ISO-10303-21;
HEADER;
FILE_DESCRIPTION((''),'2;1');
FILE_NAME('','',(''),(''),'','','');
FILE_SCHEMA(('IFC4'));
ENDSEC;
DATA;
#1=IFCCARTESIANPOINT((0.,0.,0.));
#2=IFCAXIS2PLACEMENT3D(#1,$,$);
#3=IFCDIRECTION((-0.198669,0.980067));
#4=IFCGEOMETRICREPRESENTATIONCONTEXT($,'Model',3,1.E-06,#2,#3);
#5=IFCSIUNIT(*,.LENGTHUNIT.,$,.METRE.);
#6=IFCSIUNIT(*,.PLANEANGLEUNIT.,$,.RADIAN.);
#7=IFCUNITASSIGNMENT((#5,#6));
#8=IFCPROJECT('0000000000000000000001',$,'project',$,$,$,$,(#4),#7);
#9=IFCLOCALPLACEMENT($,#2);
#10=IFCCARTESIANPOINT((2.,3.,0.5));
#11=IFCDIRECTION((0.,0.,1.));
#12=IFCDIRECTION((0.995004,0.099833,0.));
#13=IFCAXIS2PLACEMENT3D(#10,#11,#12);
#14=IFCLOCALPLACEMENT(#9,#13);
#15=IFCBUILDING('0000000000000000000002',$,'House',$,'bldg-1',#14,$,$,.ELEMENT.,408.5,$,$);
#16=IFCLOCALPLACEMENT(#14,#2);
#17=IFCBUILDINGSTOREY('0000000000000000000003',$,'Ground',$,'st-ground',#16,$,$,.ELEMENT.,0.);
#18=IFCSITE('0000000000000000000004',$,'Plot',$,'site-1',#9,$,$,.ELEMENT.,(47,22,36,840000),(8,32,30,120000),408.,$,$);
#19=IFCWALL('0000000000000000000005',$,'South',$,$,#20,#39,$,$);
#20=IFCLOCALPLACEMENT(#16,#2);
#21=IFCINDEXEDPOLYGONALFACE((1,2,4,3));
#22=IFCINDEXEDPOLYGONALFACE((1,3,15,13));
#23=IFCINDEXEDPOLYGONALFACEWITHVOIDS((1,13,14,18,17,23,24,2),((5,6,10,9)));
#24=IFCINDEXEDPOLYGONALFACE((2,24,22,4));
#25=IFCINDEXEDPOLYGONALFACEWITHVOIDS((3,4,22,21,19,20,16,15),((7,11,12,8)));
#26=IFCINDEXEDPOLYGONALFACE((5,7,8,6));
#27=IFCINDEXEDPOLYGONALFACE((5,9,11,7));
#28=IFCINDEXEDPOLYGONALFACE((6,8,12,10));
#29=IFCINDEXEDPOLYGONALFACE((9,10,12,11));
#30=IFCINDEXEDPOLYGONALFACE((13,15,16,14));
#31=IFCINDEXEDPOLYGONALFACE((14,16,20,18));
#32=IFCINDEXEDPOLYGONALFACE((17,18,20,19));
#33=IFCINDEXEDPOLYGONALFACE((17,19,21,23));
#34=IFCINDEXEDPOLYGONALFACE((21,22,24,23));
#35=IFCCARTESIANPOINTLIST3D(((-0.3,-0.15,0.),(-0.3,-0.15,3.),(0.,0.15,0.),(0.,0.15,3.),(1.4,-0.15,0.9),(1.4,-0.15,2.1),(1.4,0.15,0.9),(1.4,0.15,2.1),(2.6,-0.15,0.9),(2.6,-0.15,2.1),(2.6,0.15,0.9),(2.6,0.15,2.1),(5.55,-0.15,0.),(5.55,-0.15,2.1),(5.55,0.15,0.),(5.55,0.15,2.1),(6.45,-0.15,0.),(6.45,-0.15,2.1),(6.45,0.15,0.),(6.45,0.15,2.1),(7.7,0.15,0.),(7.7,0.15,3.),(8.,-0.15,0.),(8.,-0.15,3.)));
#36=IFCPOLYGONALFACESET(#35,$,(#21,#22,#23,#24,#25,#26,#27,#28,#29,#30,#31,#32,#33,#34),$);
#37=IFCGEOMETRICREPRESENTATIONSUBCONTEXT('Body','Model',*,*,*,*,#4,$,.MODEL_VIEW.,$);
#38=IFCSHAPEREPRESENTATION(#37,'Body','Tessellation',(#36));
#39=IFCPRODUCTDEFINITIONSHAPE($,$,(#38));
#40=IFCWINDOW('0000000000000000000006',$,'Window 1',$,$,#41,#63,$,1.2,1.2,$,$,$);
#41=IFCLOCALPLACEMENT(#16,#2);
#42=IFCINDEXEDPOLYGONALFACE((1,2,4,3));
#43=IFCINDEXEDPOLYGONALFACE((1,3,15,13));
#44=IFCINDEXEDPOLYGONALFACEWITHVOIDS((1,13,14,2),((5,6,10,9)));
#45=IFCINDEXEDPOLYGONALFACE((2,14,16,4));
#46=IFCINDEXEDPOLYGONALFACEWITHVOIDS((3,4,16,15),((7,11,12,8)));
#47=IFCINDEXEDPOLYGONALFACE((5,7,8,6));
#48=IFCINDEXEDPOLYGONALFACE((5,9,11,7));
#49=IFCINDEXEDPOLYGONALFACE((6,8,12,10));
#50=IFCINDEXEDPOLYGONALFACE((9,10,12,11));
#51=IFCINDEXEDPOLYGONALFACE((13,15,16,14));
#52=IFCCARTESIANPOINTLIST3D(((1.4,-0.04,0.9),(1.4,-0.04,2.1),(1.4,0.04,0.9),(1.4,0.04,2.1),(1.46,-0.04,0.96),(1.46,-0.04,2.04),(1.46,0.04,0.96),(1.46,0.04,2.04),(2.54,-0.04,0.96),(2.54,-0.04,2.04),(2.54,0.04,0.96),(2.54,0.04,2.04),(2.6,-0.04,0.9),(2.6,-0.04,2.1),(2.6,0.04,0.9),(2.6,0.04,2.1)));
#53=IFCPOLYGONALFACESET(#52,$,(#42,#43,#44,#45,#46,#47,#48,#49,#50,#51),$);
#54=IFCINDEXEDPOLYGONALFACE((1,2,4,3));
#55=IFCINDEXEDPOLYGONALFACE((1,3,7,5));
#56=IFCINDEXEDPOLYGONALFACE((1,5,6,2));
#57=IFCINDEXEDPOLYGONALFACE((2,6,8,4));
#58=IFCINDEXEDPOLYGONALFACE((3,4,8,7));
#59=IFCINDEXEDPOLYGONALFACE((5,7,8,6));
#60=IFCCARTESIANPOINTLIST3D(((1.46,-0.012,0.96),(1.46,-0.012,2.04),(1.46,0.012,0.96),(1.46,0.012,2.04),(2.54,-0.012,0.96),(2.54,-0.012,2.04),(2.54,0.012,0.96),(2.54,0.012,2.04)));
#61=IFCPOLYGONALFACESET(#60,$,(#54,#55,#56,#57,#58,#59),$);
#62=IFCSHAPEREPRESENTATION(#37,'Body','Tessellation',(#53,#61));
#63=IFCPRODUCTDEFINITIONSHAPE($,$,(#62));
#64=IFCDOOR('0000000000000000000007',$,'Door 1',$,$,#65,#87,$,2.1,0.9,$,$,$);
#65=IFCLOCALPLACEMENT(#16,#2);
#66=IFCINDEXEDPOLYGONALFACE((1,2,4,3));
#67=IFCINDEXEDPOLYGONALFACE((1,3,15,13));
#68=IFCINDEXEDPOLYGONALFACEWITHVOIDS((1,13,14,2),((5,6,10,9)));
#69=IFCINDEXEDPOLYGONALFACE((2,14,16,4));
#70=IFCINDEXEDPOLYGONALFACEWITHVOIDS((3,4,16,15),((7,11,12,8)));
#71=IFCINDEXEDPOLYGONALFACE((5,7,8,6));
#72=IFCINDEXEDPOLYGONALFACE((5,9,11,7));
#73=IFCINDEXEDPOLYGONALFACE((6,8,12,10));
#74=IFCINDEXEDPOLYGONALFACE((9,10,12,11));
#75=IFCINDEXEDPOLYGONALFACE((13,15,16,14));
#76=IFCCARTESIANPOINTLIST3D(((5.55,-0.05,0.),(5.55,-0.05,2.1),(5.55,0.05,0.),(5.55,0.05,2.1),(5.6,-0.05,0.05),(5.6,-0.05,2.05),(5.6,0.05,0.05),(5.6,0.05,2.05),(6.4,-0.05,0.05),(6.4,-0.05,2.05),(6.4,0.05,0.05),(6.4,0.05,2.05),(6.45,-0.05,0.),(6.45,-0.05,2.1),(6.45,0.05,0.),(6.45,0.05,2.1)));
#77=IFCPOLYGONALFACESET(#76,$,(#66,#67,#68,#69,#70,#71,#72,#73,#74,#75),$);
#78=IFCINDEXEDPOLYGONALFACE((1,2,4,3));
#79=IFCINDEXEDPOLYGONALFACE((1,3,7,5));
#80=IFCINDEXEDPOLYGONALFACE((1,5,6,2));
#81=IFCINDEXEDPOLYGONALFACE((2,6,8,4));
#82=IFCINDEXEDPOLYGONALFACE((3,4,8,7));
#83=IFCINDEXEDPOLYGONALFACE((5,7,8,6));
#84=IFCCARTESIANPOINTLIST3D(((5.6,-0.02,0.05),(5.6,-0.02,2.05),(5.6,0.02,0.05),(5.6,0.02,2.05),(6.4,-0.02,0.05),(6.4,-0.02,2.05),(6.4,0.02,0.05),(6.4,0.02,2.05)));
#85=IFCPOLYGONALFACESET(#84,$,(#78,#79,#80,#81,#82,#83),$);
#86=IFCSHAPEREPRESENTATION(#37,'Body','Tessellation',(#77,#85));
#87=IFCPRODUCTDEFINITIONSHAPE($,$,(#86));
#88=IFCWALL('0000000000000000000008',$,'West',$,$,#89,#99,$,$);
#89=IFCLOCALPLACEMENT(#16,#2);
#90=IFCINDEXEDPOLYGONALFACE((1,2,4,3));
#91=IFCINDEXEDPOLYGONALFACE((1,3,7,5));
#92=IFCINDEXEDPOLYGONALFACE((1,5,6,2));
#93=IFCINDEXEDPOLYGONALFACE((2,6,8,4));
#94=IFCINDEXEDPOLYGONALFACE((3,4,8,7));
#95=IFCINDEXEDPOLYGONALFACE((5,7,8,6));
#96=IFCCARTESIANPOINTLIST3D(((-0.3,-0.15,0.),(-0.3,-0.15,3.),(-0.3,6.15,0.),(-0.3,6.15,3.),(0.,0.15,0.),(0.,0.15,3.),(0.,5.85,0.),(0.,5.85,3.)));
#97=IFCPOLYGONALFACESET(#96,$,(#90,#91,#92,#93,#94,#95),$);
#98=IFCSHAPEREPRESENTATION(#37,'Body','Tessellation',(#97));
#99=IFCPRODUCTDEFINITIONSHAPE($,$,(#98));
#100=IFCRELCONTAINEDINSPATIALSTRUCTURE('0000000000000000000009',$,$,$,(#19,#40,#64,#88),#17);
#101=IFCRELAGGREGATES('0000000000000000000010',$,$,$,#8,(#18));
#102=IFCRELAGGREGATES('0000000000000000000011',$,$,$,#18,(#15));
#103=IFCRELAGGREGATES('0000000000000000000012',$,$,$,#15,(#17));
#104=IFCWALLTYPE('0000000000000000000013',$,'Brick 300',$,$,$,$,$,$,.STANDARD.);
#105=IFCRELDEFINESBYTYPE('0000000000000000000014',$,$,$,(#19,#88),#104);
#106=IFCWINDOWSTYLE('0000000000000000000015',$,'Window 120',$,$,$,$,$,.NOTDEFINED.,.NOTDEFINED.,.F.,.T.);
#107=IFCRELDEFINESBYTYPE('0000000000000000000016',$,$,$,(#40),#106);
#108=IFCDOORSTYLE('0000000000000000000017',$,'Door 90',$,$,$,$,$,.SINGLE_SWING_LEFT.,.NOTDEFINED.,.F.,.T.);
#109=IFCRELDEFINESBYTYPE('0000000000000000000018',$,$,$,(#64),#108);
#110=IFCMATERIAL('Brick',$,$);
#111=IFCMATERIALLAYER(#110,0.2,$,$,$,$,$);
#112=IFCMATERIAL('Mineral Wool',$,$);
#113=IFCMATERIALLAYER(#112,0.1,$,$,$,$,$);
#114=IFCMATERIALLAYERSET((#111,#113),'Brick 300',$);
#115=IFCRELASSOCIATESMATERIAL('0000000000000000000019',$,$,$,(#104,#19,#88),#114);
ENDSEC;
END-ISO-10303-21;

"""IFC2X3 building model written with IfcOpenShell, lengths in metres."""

from ifc_helpers import new_model, si_unit, direction, frame, frame_2d, origin, origin_2d, place, context, subcontext, project, spatial, polyline, rectangle, outline, extrude, material, layer, layer_set, layer_usage, type_object, element, fill, save


model = new_model("IFC2X3")

# Units and contexts
model_context = context("Model", 3, precision=1e-06, world=origin(), true_north=direction((-0.198669, 0.980067)))
body_context = subcontext(model_context, "Body", "Model", "MODEL_VIEW")
ifc_project = project(units=[si_unit("LENGTHUNIT", "METRE"), si_unit("PLANEANGLEUNIT", "RADIAN")], contexts=[model_context])

# Site, building, storey
site_placement = place(None, origin())
site = spatial("IfcSite", under=ifc_project, at=site_placement, Name="Plot", ObjectType="site-1", CompositionType="ELEMENT", RefLatitude=(47, 22, 36, 840000), RefLongitude=(8, 32, 30, 120000), RefElevation=408.0)
building_placement = place(site_placement, frame((2.0, 3.0, 0.5), z_axis=(0.0, 0.0, 1.0), x_axis=(0.995004, 0.099833, 0.0)))
building = spatial("IfcBuilding", under=site, at=building_placement, Name="House", ObjectType="bldg-1", CompositionType="ELEMENT", ElevationOfRefHeight=408.5)
storey_placement = place(building_placement, origin())
storey = spatial("IfcBuildingStorey", under=building, at=storey_placement, Name="Ground", ObjectType="st-ground", CompositionType="ELEMENT", Elevation=0.0)

# Shared definitions
window_style = type_object("IfcWindowStyle", Name="Window 120", ConstructionType="NOTDEFINED", OperationType="NOTDEFINED", ParameterTakesPrecedence=False, Sizeable=True)

# Shared definitions
ifc_material_1 = material(Name="Brick")
ifc_layer_1 = layer(ifc_material_1, 0.2)
ifc_material_2 = material(Name="Mineral Wool")
ifc_layer_2 = layer(ifc_material_2, 0.1)
ifc_layer_set_1 = layer_set([ifc_layer_1, ifc_layer_2], Name="Brick 300")
wall_type_1 = type_object("IfcWallType", Name="Brick 300", PredefinedType="STANDARD", material=ifc_layer_set_1)

# Wall, openings, window, door
ifc_layer_usage_1 = layer_usage(ifc_layer_set_1, "AXIS2", "NEGATIVE", 0.15)
wall_1_placement = place(storey_placement, origin())
wall_1 = element("IfcWall", 1, at=wall_1_placement, inside=storey, type_object=wall_type_1, material=ifc_layer_usage_1, Name="South", context=body_context, shape_type="SweptSolid", body=[
    extrude(outline(polyline([(-0.3, -0.15), (8.0, -0.15), (7.7, 0.15), (0.0, 0.15), (-0.3, -0.15)])), origin(), (0.0, 0.0, 1.0), 3.0),
])
opening_1_placement = place(wall_1_placement, frame((6.0, 0.0, 0.0), z_axis=(0.0, 0.0, 1.0), x_axis=(1.0, 0.0, 0.0)))
opening_1 = element("IfcOpeningElement", 2, at=opening_1_placement, cuts=wall_1, context=body_context, shape_type="SweptSolid", body=[
    extrude(rectangle(XDim=0.9, YDim=0.3, at=origin_2d()), origin(), (0.0, 0.0, 1.0), 2.1),
])
opening_2_placement = place(wall_1_placement, frame((2.0, 0.0, 0.9), z_axis=(0.0, 0.0, 1.0), x_axis=(1.0, 0.0, 0.0)))
opening_2 = element("IfcOpeningElement", 3, at=opening_2_placement, cuts=wall_1, context=body_context, shape_type="SweptSolid", body=[
    extrude(rectangle(XDim=1.2, YDim=0.3, at=origin_2d()), origin(), (0.0, 0.0, 1.0), 1.2),
])
window_1_placement = place(opening_2_placement, frame((0.0, 0.0, 0.0), z_axis=(0.0, -1.0, 0.0), x_axis=(1.0, 0.0, 0.0)))
window_1 = element("IfcWindow", 4, at=window_1_placement, inside=storey, type_object=window_style, Name="Window 1", OverallHeight=1.2, OverallWidth=1.2, context=body_context, shape_type="SweptSolid", body=[
    extrude(outline(polyline([(-0.6, 0.0), (0.6, 0.0), (0.6, 1.2), (-0.6, 1.2), (-0.6, 0.0)]), holes=[polyline([(-0.54, 0.06), (0.54, 0.06), (0.54, 1.14), (-0.54, 1.14), (-0.54, 0.06)])]), frame((0.0, 0.0, -0.04)), (0.0, 0.0, 1.0), 0.08),
    extrude(rectangle(XDim=1.08, YDim=1.08, at=frame_2d((0.0, 0.6))), frame((0.0, 0.0, -0.012)), (0.0, 0.0, 1.0), 0.024),
])
fill(opening_2, window_1)
door_style = type_object("IfcDoorStyle", Name="Door 90", ConstructionType="NOTDEFINED", OperationType="SINGLE_SWING_LEFT", ParameterTakesPrecedence=False, Sizeable=True)
door_placement = place(opening_1_placement, frame((0.0, 0.0, 0.0), z_axis=(0.0, -1.0, 0.0), x_axis=(1.0, 0.0, 0.0)))
door = element("IfcDoor", 5, at=door_placement, inside=storey, type_object=door_style, Name="Door 1", OverallHeight=2.1, OverallWidth=0.9, context=body_context, shape_type="SweptSolid", body=[
    extrude(outline(polyline([(-0.45, 0.0), (0.45, 0.0), (0.45, 2.1), (-0.45, 2.1), (-0.45, 0.0)]), holes=[polyline([(-0.4, 0.05), (0.4, 0.05), (0.4, 2.05), (-0.4, 2.05), (-0.4, 0.05)])]), frame((0.0, 0.0, -0.05)), (0.0, 0.0, 1.0), 0.1),
    extrude(rectangle(XDim=0.8, YDim=2.0, at=frame_2d((0.0, 1.05))), frame((0.0, 0.0, -0.02)), (0.0, 0.0, 1.0), 0.04),
])
fill(opening_1, door)

# Wall
ifc_layer_usage_2 = layer_usage(ifc_layer_set_1, "AXIS2", "NEGATIVE", 0.0)
wall_2_placement = place(storey_placement, origin())
element("IfcWall", 6, at=wall_2_placement, inside=storey, type_object=wall_type_1, material=ifc_layer_usage_2, Name="West", context=body_context, shape_type="SweptSolid", body=[
    extrude(outline(polyline([(-0.3, 6.15), (-0.3, -0.15), (0.0, 0.15), (0.0, 5.85), (-0.3, 6.15)])), origin(), (0.0, 0.0, 1.0), 3.0),
])

save(model, "model.ifc")
